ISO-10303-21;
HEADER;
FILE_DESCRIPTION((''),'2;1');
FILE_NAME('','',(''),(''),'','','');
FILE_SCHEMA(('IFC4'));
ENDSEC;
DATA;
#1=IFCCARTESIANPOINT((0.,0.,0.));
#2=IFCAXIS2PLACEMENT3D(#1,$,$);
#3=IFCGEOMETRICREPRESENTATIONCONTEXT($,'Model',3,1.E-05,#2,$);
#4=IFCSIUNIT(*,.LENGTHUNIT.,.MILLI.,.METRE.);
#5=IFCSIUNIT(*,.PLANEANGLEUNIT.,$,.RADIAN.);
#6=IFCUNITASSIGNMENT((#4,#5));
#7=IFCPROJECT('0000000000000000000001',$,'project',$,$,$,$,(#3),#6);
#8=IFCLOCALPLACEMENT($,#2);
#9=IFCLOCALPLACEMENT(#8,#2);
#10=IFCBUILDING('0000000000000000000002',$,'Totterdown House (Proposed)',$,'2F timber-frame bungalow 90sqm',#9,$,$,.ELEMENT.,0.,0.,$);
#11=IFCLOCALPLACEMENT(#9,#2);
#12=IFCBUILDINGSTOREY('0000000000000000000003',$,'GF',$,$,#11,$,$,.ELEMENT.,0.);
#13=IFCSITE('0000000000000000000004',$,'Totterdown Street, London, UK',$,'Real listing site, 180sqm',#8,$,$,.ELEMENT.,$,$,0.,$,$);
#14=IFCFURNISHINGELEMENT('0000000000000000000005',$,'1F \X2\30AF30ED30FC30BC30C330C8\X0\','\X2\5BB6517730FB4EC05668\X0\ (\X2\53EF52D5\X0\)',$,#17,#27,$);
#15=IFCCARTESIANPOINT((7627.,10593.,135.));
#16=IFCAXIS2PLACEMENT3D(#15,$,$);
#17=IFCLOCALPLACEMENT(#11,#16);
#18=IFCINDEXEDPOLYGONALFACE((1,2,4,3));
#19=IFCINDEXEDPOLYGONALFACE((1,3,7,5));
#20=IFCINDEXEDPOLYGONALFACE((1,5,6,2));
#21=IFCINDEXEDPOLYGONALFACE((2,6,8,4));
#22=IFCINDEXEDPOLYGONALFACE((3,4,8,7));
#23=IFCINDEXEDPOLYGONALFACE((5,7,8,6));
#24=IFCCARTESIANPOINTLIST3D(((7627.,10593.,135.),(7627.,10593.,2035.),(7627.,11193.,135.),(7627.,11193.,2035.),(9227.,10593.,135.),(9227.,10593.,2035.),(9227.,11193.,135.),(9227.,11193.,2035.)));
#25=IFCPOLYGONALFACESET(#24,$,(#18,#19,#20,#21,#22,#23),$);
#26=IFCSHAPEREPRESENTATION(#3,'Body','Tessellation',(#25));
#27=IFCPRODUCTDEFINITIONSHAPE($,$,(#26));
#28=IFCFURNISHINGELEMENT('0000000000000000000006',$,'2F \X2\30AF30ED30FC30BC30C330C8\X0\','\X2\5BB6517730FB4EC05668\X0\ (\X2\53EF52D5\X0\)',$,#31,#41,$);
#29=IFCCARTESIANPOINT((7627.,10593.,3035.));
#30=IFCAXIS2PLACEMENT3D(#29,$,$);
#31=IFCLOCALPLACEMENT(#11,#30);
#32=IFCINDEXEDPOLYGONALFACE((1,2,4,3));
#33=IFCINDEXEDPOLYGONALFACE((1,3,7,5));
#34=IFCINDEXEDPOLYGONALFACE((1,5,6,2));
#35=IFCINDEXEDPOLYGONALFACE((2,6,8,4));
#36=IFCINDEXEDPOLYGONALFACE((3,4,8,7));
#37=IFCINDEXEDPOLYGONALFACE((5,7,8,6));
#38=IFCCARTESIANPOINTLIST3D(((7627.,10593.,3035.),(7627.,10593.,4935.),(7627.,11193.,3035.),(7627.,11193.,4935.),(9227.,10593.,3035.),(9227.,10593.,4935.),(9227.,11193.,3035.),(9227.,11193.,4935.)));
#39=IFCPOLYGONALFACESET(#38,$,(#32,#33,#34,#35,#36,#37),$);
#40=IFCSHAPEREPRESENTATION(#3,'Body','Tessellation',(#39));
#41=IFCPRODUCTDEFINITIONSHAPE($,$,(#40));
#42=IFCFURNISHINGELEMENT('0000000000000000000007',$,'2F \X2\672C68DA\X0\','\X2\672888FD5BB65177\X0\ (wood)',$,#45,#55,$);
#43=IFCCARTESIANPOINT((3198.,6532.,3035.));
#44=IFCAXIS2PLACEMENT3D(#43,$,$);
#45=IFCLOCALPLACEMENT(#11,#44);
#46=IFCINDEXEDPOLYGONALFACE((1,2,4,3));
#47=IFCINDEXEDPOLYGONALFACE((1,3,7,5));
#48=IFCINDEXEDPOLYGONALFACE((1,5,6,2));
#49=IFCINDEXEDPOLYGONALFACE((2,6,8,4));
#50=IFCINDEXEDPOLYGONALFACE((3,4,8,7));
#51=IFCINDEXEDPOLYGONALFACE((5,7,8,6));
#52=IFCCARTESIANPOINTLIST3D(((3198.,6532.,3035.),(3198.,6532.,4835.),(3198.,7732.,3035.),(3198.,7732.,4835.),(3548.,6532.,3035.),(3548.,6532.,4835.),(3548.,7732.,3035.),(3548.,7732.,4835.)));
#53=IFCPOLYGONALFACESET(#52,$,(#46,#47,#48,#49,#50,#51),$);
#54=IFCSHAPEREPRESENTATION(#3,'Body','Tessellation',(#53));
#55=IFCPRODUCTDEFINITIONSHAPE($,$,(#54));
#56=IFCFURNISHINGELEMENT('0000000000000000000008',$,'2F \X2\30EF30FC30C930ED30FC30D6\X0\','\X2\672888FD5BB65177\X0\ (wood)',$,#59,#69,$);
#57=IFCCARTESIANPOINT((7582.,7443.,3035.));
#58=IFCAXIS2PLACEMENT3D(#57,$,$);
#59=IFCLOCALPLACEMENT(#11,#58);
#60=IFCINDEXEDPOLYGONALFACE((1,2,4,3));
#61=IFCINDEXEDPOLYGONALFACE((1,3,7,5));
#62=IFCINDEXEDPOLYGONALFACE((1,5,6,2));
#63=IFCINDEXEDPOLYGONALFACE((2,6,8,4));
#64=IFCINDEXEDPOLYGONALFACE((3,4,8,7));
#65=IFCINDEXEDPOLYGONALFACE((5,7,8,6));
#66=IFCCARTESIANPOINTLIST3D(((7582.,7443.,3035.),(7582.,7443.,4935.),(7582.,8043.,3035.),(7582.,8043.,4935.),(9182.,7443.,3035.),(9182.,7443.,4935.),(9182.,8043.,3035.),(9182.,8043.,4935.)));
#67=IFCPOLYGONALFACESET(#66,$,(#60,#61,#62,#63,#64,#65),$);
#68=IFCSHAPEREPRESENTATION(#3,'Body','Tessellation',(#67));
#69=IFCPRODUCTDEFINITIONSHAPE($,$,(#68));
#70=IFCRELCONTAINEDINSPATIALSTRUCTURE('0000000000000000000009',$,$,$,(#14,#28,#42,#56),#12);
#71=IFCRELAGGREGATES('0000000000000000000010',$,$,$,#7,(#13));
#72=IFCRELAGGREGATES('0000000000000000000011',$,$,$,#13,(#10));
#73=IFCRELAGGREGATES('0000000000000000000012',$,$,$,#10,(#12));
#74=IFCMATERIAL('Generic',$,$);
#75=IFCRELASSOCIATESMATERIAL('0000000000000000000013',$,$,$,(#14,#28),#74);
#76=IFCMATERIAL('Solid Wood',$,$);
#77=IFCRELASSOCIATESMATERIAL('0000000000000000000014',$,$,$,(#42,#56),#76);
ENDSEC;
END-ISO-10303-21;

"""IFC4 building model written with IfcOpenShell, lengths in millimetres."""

from ifc_helpers import new_model, si_unit, frame, frame_2d, origin, place, context, project, spatial, rectangle, extrude, material, element, save


model = new_model("IFC4")

# Units and contexts
model_context = context("Model", 3, precision=1e-05, world=origin())
ifc_project = project(units=[si_unit("LENGTHUNIT", "METRE", prefix="MILLI"), si_unit("PLANEANGLEUNIT", "RADIAN")], contexts=[model_context])

# Site, building, storey
site_placement = place(None, origin())
site = spatial("IfcSite", under=ifc_project, at=site_placement, Name="Totterdown Street, London, UK", ObjectType="Real listing site, 180sqm", CompositionType="ELEMENT", RefElevation=0.0)
building_placement = place(site_placement, origin())
building = spatial("IfcBuilding", under=site, at=building_placement, Name="Totterdown House (Proposed)", ObjectType="2F timber-frame bungalow 90sqm", CompositionType="ELEMENT", ElevationOfRefHeight=0.0, ElevationOfTerrain=0.0)
storey_placement = place(building_placement, origin())
storey = spatial("IfcBuildingStorey", under=building, at=storey_placement, Name="GF", CompositionType="ELEMENT", Elevation=0.0)

# Shared definitions
ifc_material_1 = material(Name="Solid Wood")

# Shared definitions
ifc_material_2 = material(Name="Generic")

# Furnishing elements
furnishing_1_placement = place(storey_placement, frame((7627.0, 10593.0, 135.0)))
element("IfcFurnishingElement", 1, at=furnishing_1_placement, inside=storey, material=ifc_material_2, Name="1F クローゼット", Description="家具・什器 (可動)", context=model_context, shape_type="SweptSolid", body=[
    extrude(rectangle(XDim=1600.0, YDim=600.0, at=frame_2d((800.0, 300.0))), frame((7627.0, 10593.0, 135.0)), (0.0, 0.0, 1.0), 1900.0),
])
furnishing_2_placement = place(storey_placement, frame((7627.0, 10593.0, 3035.0)))
element("IfcFurnishingElement", 2, at=furnishing_2_placement, inside=storey, material=ifc_material_2, Name="2F クローゼット", Description="家具・什器 (可動)", context=model_context, shape_type="SweptSolid", body=[
    extrude(rectangle(XDim=1600.0, YDim=600.0, at=frame_2d((800.0, 300.0))), frame((7627.0, 10593.0, 3035.0)), (0.0, 0.0, 1.0), 1900.0),
])
furnishing_3_placement = place(storey_placement, frame((3198.0, 6532.0, 3035.0)))
element("IfcFurnishingElement", 3, at=furnishing_3_placement, inside=storey, material=ifc_material_1, Name="2F 本棚", Description="木製家具 (wood)", context=model_context, shape_type="SweptSolid", body=[
    extrude(rectangle(XDim=350.0, YDim=1200.0, at=frame_2d((175.0, 600.0))), frame((3198.0, 6532.0, 3035.0)), (0.0, 0.0, 1.0), 1800.0),
])
furnishing_4_placement = place(storey_placement, frame((7582.0, 7443.0, 3035.0)))
element("IfcFurnishingElement", 4, at=furnishing_4_placement, inside=storey, material=ifc_material_1, Name="2F ワードローブ", Description="木製家具 (wood)", context=model_context, shape_type="SweptSolid", body=[
    extrude(rectangle(XDim=1600.0, YDim=600.0, at=frame_2d((800.0, 300.0))), frame((7582.0, 7443.0, 3035.0)), (0.0, 0.0, 1.0), 1900.0),
])

save(model, "model.ifc")
